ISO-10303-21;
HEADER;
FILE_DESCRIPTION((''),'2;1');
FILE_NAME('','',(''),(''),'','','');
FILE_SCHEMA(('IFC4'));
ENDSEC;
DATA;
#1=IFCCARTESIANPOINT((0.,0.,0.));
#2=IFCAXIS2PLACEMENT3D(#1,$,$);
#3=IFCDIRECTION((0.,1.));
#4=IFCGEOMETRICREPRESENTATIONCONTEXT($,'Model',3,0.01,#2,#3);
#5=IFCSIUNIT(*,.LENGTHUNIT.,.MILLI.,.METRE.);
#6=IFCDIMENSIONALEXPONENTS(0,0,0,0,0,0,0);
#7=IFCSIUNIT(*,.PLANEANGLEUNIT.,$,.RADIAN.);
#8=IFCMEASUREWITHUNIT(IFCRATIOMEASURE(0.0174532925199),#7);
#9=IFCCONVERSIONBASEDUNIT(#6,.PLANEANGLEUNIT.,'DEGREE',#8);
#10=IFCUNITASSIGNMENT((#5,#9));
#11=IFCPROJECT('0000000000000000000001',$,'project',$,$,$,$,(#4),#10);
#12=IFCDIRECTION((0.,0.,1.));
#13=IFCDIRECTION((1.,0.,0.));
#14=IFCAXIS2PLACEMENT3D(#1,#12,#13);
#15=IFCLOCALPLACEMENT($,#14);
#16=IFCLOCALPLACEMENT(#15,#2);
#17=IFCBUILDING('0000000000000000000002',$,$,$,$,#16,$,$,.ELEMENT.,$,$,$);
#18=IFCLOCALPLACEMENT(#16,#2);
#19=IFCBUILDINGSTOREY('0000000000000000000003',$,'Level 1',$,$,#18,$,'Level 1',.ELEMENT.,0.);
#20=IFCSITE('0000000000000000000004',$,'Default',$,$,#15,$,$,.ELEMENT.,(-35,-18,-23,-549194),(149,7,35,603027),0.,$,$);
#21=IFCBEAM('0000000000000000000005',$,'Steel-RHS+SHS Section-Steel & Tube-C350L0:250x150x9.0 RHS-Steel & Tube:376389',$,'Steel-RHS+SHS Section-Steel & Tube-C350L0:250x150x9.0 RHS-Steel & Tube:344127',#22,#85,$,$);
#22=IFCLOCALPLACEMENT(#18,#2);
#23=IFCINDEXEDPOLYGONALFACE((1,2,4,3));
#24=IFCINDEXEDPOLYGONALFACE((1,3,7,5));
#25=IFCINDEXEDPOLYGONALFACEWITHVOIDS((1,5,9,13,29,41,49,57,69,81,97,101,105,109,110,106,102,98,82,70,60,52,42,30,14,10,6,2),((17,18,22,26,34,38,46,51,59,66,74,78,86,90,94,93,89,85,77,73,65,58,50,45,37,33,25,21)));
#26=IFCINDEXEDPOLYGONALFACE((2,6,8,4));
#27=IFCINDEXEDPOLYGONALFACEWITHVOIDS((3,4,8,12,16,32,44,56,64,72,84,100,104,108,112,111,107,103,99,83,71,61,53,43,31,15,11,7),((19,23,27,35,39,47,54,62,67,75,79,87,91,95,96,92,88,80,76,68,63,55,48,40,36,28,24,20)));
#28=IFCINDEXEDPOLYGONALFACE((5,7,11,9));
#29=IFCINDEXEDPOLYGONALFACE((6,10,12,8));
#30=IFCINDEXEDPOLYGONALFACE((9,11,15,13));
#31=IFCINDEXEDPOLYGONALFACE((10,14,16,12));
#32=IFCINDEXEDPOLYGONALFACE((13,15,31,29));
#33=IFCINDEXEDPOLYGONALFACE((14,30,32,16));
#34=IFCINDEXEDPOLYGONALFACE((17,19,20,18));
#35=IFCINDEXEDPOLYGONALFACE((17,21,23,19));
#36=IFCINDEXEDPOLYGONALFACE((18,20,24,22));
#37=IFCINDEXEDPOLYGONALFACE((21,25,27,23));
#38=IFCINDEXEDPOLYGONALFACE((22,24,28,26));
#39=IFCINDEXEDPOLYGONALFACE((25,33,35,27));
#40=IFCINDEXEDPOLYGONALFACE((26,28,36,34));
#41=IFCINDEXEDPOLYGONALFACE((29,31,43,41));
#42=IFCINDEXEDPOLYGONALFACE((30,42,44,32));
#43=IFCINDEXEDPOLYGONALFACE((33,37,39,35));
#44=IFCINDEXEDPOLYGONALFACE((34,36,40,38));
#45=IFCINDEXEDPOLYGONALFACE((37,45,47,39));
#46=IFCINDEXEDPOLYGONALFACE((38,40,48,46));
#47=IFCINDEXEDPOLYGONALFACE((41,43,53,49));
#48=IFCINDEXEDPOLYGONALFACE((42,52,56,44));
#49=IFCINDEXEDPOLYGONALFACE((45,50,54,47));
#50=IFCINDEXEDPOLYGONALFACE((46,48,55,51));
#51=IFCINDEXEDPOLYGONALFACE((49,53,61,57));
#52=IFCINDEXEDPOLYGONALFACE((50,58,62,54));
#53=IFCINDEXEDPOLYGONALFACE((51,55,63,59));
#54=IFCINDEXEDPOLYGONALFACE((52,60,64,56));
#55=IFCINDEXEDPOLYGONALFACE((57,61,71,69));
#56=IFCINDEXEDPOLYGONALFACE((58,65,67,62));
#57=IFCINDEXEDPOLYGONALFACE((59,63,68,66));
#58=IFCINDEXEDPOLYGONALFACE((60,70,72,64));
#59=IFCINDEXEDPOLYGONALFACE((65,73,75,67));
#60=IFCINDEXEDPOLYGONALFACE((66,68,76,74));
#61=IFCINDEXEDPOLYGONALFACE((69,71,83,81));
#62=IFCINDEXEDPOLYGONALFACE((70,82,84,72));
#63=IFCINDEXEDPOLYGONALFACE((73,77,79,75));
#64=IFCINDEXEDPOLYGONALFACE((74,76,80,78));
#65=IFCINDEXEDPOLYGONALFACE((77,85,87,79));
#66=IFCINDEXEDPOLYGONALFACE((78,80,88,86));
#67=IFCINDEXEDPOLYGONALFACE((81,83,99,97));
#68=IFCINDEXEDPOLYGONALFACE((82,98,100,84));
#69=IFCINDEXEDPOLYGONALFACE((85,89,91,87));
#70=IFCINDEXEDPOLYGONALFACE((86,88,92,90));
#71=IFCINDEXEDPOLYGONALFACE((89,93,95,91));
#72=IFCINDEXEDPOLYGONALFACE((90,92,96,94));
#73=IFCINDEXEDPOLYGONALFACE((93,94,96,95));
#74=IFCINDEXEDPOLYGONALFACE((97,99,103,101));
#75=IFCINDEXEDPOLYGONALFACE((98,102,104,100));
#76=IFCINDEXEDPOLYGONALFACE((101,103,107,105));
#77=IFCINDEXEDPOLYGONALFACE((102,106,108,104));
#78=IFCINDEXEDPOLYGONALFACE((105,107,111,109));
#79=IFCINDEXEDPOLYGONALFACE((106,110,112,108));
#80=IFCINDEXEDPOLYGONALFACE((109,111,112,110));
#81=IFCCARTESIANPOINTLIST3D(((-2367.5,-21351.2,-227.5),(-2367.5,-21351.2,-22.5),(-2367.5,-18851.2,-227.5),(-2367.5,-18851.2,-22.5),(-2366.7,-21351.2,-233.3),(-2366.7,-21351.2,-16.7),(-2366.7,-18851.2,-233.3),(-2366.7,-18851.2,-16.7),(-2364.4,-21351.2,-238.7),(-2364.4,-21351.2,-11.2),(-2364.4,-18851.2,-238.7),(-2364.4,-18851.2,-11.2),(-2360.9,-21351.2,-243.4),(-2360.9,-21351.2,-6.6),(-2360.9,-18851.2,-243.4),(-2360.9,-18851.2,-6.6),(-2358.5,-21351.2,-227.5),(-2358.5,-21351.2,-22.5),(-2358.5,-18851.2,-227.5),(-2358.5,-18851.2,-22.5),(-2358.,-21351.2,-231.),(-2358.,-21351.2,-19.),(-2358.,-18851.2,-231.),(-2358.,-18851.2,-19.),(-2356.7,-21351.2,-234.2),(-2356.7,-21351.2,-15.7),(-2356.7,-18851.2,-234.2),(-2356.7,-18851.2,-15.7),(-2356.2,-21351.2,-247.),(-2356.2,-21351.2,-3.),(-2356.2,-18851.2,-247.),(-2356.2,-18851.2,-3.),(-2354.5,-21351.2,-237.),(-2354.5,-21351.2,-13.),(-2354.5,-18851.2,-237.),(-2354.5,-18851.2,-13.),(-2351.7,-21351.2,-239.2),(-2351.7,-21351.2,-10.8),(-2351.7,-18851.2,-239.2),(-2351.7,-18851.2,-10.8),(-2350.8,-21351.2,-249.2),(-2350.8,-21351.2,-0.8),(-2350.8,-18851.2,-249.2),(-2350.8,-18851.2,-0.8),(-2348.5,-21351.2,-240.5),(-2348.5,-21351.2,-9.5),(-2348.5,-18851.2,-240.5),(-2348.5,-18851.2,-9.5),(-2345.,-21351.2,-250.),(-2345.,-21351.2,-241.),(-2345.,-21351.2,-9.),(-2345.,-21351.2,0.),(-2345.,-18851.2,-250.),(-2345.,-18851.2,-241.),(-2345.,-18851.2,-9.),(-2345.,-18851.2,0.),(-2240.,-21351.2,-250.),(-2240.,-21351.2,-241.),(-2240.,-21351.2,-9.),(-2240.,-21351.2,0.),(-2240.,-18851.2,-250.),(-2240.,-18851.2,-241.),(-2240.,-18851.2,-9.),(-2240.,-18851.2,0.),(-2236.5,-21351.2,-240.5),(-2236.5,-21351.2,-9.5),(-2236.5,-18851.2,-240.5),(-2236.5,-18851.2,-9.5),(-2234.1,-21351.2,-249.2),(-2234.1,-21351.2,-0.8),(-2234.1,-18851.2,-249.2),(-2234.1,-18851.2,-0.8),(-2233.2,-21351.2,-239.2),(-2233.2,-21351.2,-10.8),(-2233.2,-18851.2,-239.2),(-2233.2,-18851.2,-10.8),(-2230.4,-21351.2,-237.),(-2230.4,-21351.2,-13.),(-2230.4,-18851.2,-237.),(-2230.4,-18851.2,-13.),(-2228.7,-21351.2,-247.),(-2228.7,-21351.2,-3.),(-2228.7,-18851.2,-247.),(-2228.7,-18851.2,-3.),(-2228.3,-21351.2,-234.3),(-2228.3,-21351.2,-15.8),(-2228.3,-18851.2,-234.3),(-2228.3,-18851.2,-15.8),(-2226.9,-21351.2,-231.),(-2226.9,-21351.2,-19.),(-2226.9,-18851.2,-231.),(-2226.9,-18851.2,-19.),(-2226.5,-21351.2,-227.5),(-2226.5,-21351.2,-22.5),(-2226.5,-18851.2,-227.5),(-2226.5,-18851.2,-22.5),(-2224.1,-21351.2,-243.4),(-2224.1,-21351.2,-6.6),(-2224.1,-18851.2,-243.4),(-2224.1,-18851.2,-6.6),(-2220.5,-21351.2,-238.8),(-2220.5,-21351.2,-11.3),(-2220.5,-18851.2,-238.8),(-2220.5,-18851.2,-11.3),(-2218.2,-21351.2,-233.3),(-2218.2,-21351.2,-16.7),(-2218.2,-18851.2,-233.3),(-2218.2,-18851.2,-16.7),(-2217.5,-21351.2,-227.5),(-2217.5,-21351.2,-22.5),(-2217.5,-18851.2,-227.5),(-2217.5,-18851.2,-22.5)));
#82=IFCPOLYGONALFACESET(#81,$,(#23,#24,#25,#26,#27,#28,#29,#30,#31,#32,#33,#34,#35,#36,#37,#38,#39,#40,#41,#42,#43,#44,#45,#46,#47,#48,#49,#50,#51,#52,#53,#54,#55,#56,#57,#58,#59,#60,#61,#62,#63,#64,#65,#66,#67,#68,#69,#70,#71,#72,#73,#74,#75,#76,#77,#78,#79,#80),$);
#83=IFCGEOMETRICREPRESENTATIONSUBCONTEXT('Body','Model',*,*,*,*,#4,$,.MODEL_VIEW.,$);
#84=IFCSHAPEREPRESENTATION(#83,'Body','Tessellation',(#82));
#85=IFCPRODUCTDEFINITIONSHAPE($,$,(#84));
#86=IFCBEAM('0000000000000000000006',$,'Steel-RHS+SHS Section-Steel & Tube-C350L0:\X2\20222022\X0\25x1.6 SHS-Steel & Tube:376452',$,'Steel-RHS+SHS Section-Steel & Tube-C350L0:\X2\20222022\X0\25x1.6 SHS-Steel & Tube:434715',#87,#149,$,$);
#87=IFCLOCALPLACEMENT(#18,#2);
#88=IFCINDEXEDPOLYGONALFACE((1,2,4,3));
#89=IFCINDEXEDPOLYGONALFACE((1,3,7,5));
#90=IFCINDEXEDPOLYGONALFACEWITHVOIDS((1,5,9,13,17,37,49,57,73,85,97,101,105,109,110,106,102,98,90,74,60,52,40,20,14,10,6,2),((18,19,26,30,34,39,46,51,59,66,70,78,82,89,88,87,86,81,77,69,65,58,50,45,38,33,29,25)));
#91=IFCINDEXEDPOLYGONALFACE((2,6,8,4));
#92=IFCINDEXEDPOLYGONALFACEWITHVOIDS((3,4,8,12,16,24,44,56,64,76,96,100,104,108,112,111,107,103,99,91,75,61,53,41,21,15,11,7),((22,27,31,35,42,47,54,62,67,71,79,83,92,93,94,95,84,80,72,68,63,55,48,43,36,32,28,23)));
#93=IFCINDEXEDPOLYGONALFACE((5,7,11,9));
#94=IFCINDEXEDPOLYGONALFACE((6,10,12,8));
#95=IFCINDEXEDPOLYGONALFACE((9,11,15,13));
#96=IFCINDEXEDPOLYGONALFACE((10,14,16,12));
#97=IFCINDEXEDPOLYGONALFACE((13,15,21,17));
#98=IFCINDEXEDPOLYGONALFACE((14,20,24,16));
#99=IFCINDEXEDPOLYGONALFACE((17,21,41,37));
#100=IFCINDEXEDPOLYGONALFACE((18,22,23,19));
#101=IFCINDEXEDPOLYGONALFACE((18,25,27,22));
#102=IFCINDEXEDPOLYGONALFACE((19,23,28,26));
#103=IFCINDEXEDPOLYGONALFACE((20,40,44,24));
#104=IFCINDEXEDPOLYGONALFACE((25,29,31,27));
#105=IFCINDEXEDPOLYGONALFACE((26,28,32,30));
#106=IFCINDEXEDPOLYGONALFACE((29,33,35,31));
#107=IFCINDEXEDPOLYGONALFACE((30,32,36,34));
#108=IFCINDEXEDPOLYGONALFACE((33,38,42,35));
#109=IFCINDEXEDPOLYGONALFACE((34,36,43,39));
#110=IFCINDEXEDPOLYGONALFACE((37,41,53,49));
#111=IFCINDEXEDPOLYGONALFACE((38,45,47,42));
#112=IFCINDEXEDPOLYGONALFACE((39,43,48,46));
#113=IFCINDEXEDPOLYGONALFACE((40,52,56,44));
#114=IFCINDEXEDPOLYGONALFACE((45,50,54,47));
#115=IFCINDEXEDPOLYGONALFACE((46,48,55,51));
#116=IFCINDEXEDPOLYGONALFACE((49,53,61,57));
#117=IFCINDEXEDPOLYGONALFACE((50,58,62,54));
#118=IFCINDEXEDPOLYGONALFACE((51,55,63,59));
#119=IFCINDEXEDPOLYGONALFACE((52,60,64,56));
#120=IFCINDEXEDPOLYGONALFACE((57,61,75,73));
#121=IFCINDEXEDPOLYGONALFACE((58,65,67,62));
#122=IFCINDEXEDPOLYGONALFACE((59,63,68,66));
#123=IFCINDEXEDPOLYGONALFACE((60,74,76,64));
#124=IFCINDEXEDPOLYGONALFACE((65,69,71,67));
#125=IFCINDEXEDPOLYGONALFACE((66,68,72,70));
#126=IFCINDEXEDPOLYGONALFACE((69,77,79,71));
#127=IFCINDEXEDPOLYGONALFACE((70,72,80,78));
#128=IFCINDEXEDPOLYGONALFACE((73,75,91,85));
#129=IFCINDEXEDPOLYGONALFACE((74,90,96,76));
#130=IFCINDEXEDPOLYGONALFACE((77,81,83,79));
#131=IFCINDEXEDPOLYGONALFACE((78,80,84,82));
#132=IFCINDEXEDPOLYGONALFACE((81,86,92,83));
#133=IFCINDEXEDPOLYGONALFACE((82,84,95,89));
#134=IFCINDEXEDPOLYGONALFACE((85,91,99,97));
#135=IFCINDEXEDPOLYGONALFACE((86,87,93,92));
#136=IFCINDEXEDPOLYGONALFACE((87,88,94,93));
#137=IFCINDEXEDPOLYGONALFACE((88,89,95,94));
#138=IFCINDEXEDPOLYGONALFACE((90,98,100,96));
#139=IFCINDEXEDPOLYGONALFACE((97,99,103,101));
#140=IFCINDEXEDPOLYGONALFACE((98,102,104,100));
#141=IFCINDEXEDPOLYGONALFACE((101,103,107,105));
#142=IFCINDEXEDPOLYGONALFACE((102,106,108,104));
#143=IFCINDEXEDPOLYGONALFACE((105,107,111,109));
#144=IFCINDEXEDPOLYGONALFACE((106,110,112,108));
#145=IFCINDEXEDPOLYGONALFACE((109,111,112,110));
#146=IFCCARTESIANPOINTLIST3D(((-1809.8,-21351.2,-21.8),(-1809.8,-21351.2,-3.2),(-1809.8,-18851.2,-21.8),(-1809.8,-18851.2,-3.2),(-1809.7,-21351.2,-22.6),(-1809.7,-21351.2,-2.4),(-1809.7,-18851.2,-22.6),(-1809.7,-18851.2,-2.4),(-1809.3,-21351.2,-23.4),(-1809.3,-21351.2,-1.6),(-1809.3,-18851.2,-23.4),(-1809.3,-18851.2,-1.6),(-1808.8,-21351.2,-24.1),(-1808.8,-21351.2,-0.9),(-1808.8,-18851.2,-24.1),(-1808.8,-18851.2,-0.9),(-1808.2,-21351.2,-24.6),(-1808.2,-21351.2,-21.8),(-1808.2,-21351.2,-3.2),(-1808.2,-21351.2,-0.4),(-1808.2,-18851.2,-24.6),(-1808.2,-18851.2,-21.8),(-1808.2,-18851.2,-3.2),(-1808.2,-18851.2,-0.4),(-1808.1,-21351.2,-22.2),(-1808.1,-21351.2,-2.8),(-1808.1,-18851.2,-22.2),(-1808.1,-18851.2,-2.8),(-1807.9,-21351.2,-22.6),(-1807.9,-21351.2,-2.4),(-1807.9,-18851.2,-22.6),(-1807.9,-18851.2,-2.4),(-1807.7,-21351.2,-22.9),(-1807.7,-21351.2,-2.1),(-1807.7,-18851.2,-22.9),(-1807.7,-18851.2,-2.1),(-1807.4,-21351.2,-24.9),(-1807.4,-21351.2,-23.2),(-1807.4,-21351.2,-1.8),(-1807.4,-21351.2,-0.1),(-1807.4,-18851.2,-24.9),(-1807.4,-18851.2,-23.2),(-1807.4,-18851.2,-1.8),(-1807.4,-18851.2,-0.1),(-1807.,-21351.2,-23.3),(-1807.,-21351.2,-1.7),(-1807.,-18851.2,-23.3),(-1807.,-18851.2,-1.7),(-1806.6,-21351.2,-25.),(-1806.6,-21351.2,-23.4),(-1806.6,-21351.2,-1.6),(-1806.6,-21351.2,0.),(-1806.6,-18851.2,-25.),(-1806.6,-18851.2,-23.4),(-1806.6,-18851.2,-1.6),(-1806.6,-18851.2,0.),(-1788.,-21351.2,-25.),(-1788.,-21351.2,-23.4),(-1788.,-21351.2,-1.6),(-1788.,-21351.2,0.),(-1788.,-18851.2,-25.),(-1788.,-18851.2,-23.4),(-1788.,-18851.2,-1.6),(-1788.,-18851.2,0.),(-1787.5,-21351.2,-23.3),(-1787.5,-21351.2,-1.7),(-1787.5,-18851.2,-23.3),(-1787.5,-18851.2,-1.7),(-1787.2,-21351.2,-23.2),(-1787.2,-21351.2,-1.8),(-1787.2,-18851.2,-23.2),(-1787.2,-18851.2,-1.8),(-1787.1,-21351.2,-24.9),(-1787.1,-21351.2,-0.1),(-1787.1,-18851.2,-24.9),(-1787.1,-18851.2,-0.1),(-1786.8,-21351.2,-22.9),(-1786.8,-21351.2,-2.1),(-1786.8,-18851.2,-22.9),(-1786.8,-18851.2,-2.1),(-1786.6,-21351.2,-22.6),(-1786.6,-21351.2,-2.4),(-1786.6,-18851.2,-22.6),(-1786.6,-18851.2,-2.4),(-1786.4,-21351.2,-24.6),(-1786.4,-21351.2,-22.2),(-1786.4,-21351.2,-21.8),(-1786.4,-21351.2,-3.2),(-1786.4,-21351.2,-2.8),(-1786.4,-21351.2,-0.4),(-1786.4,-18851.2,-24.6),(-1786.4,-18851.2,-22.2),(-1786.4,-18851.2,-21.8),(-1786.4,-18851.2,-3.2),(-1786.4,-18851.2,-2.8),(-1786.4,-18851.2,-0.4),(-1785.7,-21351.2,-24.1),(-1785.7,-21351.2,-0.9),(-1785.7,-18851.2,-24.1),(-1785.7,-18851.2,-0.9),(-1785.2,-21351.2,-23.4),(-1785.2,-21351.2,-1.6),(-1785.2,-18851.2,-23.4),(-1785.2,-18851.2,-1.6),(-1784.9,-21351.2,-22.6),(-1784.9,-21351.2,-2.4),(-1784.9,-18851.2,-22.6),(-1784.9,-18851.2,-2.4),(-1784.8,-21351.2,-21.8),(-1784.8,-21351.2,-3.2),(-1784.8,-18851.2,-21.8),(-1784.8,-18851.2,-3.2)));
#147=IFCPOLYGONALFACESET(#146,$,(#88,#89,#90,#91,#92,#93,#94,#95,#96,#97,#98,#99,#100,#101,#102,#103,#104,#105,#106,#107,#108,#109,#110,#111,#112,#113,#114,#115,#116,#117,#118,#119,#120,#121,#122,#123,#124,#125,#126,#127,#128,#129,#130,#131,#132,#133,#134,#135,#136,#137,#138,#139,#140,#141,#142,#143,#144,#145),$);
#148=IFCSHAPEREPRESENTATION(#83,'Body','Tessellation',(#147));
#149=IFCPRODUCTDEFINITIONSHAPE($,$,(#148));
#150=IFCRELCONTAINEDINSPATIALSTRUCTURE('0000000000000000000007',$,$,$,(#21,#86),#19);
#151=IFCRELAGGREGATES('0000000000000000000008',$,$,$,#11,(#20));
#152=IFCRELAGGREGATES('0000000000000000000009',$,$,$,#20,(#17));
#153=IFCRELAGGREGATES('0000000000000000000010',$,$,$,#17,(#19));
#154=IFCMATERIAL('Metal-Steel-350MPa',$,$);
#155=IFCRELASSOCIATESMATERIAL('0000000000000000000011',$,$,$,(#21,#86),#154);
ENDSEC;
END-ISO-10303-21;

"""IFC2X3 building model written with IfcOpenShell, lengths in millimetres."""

from ifc_helpers import new_model, entity, si_unit, converted_unit, direction, frame, frame_2d, origin, origin_with_axes, place, context, subcontext, project, spatial, polyline, circle_curve, parameter, trimmed, segment, composite_curve, outline, extrude, material, element, save


model = new_model("IFC2X3")

# Units and contexts
model_context = context("Model", 3, precision=0.01, world=origin(), true_north=direction((0.0, 1.0)))
body_context = subcontext(model_context, "Body", "Model", "MODEL_VIEW")
ifc_project = project(units=[si_unit("LENGTHUNIT", "METRE", prefix="MILLI"), converted_unit("PLANEANGLEUNIT", "DEGREE", entity("IfcRatioMeasure", 0.0174532925199), si_unit("PLANEANGLEUNIT", "RADIAN"), dimensions=[0, 0, 0, 0, 0, 0, 0])], contexts=[model_context])

# Site, building, storey
site_placement = place(None, origin_with_axes())
site = spatial("IfcSite", under=ifc_project, at=site_placement, Name="Default", CompositionType="ELEMENT", RefLatitude=(-35, -18, -23, -549194), RefLongitude=(149, 7, 35, 603027), RefElevation=0.0)
building_placement = place(site_placement, origin())
building = spatial("IfcBuilding", under=site, at=building_placement, CompositionType="ELEMENT")
storey_placement = place(building_placement, origin())
storey = spatial("IfcBuildingStorey", under=building, at=storey_placement, Name="Level 1", LongName="Level 1", CompositionType="ELEMENT", Elevation=0.0)

# Beams
ifc_material = material(Name="Metal-Steel-350MPa")
beam_1_placement = place(storey_placement, frame((-2292.5, -18851.2, 0.0), z_axis=(0.0, 0.0, 1.0), x_axis=(0.0, -1.0, 0.0)))
element("IfcBeam", 1, at=beam_1_placement, inside=storey, material=ifc_material, Name="Steel-RHS+SHS Section-Steel & Tube-C350L0:250x150x9.0 RHS-Steel & Tube:376389", ObjectType="Steel-RHS+SHS Section-Steel & Tube-C350L0:250x150x9.0 RHS-Steel & Tube:344127", context=body_context, shape_type="SweptSolid", body=[
    extrude(outline(composite_curve([segment(trimmed(circle_curve(frame_2d((-52.5, -102.5), x_axis=(1.0, 0.0)), 22.5), [parameter(180.0)], [parameter(270.0)], True, "PARAMETER"), True, "CONTINUOUS"), segment(polyline([(-52.5, -125.0), (52.5, -125.0)]), True, "CONTINUOUS"), segment(trimmed(circle_curve(frame_2d((52.5, -102.5), x_axis=(1.0, 0.0)), 22.5), [parameter(270.0)], [parameter(0.0)], True, "PARAMETER"), True, "CONTINUOUS"), segment(polyline([(75.0, -102.5), (75.0, 102.5)]), True, "CONTINUOUS"), segment(trimmed(circle_curve(frame_2d((52.5, 102.5), x_axis=(1.0, 0.0)), 22.5), [parameter(0.0)], [parameter(90.0)], True, "PARAMETER"), True, "CONTINUOUS"), segment(polyline([(52.5, 125.0), (-52.5, 125.0)]), True, "CONTINUOUS"), segment(trimmed(circle_curve(frame_2d((-52.5, 102.5), x_axis=(1.0, 0.0)), 22.5), [parameter(90.0)], [parameter(180.0)], True, "PARAMETER"), True, "CONTINUOUS"), segment(polyline([(-75.0, 102.5), (-75.0, -102.5)]), True, "CONTINUOUS")], self_intersect=False), holes=[composite_curve([segment(polyline([(52.5, -116.0), (-52.5, -116.0)]), True, "CONTINUOUS"), segment(trimmed(circle_curve(frame_2d((-52.5, -102.5), x_axis=(1.0, 0.0)), 13.5), [parameter(180.0)], [parameter(270.0)], True, "PARAMETER"), False, "CONTINUOUS"), segment(polyline([(-66.0, -102.5), (-66.0, 102.5)]), True, "CONTINUOUS"), segment(trimmed(circle_curve(frame_2d((-52.5, 102.5), x_axis=(1.0, 0.0)), 13.5), [parameter(90.0)], [parameter(180.0)], True, "PARAMETER"), False, "CONTINUOUS"), segment(polyline([(-52.5, 116.0), (52.5, 116.0)]), True, "CONTINUOUS"), segment(trimmed(circle_curve(frame_2d((52.5, 102.5), x_axis=(1.0, 0.0)), 13.5), [parameter(360.0)], [parameter(90.0)], True, "PARAMETER"), False, "CONTINUOUS"), segment(polyline([(66.0, 102.5), (66.0, -102.5)]), True, "CONTINUOUS"), segment(trimmed(circle_curve(frame_2d((52.5, -102.5), x_axis=(1.0, 0.0)), 13.5), [parameter(270.0)], [parameter(360.0)], True, "PARAMETER"), False, "CONTINUOUS")], self_intersect=False)]), frame((0.0, 0.0, -125.0), z_axis=(1.0, 0.0, 0.0), x_axis=(0.0, -1.0, 0.0)), (0.0, 0.0, 1.0), 2500.0),
])
beam_2_placement = place(storey_placement, frame((-1797.3, -18851.2, 0.0), z_axis=(0.0, 0.0, 1.0), x_axis=(0.0, -1.0, 0.0)))
element("IfcBeam", 2, at=beam_2_placement, inside=storey, material=ifc_material, Name="Steel-RHS+SHS Section-Steel & Tube-C350L0:••25x1.6 SHS-Steel & Tube:376452", ObjectType="Steel-RHS+SHS Section-Steel & Tube-C350L0:••25x1.6 SHS-Steel & Tube:434715", context=body_context, shape_type="SweptSolid", body=[
    extrude(outline(composite_curve([segment(trimmed(circle_curve(frame_2d((-9.3, -9.3), x_axis=(1.0, 0.0)), 3.2), [parameter(180.0)], [parameter(270.0)], True, "PARAMETER"), True, "CONTINUOUS"), segment(polyline([(-9.3, -12.5), (9.3, -12.5)]), True, "CONTINUOUS"), segment(trimmed(circle_curve(frame_2d((9.3, -9.3), x_axis=(1.0, 0.0)), 3.2), [parameter(270.0)], [parameter(0.0)], True, "PARAMETER"), True, "CONTINUOUS"), segment(polyline([(12.5, -9.3), (12.5, 9.3)]), True, "CONTINUOUS"), segment(trimmed(circle_curve(frame_2d((9.3, 9.3), x_axis=(1.0, 0.0)), 3.2), [parameter(0.0)], [parameter(90.0)], True, "PARAMETER"), True, "CONTINUOUS"), segment(polyline([(9.3, 12.5), (-9.3, 12.5)]), True, "CONTINUOUS"), segment(trimmed(circle_curve(frame_2d((-9.3, 9.3), x_axis=(1.0, 0.0)), 3.2), [parameter(90.0)], [parameter(180.0)], True, "PARAMETER"), True, "CONTINUOUS"), segment(polyline([(-12.5, 9.3), (-12.5, -9.3)]), True, "CONTINUOUS")], self_intersect=False), holes=[composite_curve([segment(polyline([(9.3, -10.9), (-9.3, -10.9)]), True, "CONTINUOUS"), segment(trimmed(circle_curve(frame_2d((-9.3, -9.3), x_axis=(1.0, 0.0)), 1.6), [parameter(180.0)], [parameter(270.0)], True, "PARAMETER"), False, "CONTINUOUS"), segment(polyline([(-10.9, -9.3), (-10.9, 9.3)]), True, "CONTINUOUS"), segment(trimmed(circle_curve(frame_2d((-9.3, 9.3), x_axis=(1.0, 0.0)), 1.6), [parameter(90.0)], [parameter(180.0)], True, "PARAMETER"), False, "CONTINUOUS"), segment(polyline([(-9.3, 10.9), (9.3, 10.9)]), True, "CONTINUOUS"), segment(trimmed(circle_curve(frame_2d((9.3, 9.3), x_axis=(1.0, 0.0)), 1.6), [parameter(360.0)], [parameter(90.0)], True, "PARAMETER"), False, "CONTINUOUS"), segment(polyline([(10.9, 9.3), (10.9, -9.3)]), True, "CONTINUOUS"), segment(trimmed(circle_curve(frame_2d((9.3, -9.3), x_axis=(1.0, 0.0)), 1.6), [parameter(270.0)], [parameter(0.0)], True, "PARAMETER"), False, "CONTINUOUS")], self_intersect=False)]), frame((0.0, 0.0, -12.5), z_axis=(1.0, 0.0, 0.0), x_axis=(0.0, -1.0, 0.0)), (0.0, 0.0, 1.0), 2500.0),
])

save(model, "model.ifc")
